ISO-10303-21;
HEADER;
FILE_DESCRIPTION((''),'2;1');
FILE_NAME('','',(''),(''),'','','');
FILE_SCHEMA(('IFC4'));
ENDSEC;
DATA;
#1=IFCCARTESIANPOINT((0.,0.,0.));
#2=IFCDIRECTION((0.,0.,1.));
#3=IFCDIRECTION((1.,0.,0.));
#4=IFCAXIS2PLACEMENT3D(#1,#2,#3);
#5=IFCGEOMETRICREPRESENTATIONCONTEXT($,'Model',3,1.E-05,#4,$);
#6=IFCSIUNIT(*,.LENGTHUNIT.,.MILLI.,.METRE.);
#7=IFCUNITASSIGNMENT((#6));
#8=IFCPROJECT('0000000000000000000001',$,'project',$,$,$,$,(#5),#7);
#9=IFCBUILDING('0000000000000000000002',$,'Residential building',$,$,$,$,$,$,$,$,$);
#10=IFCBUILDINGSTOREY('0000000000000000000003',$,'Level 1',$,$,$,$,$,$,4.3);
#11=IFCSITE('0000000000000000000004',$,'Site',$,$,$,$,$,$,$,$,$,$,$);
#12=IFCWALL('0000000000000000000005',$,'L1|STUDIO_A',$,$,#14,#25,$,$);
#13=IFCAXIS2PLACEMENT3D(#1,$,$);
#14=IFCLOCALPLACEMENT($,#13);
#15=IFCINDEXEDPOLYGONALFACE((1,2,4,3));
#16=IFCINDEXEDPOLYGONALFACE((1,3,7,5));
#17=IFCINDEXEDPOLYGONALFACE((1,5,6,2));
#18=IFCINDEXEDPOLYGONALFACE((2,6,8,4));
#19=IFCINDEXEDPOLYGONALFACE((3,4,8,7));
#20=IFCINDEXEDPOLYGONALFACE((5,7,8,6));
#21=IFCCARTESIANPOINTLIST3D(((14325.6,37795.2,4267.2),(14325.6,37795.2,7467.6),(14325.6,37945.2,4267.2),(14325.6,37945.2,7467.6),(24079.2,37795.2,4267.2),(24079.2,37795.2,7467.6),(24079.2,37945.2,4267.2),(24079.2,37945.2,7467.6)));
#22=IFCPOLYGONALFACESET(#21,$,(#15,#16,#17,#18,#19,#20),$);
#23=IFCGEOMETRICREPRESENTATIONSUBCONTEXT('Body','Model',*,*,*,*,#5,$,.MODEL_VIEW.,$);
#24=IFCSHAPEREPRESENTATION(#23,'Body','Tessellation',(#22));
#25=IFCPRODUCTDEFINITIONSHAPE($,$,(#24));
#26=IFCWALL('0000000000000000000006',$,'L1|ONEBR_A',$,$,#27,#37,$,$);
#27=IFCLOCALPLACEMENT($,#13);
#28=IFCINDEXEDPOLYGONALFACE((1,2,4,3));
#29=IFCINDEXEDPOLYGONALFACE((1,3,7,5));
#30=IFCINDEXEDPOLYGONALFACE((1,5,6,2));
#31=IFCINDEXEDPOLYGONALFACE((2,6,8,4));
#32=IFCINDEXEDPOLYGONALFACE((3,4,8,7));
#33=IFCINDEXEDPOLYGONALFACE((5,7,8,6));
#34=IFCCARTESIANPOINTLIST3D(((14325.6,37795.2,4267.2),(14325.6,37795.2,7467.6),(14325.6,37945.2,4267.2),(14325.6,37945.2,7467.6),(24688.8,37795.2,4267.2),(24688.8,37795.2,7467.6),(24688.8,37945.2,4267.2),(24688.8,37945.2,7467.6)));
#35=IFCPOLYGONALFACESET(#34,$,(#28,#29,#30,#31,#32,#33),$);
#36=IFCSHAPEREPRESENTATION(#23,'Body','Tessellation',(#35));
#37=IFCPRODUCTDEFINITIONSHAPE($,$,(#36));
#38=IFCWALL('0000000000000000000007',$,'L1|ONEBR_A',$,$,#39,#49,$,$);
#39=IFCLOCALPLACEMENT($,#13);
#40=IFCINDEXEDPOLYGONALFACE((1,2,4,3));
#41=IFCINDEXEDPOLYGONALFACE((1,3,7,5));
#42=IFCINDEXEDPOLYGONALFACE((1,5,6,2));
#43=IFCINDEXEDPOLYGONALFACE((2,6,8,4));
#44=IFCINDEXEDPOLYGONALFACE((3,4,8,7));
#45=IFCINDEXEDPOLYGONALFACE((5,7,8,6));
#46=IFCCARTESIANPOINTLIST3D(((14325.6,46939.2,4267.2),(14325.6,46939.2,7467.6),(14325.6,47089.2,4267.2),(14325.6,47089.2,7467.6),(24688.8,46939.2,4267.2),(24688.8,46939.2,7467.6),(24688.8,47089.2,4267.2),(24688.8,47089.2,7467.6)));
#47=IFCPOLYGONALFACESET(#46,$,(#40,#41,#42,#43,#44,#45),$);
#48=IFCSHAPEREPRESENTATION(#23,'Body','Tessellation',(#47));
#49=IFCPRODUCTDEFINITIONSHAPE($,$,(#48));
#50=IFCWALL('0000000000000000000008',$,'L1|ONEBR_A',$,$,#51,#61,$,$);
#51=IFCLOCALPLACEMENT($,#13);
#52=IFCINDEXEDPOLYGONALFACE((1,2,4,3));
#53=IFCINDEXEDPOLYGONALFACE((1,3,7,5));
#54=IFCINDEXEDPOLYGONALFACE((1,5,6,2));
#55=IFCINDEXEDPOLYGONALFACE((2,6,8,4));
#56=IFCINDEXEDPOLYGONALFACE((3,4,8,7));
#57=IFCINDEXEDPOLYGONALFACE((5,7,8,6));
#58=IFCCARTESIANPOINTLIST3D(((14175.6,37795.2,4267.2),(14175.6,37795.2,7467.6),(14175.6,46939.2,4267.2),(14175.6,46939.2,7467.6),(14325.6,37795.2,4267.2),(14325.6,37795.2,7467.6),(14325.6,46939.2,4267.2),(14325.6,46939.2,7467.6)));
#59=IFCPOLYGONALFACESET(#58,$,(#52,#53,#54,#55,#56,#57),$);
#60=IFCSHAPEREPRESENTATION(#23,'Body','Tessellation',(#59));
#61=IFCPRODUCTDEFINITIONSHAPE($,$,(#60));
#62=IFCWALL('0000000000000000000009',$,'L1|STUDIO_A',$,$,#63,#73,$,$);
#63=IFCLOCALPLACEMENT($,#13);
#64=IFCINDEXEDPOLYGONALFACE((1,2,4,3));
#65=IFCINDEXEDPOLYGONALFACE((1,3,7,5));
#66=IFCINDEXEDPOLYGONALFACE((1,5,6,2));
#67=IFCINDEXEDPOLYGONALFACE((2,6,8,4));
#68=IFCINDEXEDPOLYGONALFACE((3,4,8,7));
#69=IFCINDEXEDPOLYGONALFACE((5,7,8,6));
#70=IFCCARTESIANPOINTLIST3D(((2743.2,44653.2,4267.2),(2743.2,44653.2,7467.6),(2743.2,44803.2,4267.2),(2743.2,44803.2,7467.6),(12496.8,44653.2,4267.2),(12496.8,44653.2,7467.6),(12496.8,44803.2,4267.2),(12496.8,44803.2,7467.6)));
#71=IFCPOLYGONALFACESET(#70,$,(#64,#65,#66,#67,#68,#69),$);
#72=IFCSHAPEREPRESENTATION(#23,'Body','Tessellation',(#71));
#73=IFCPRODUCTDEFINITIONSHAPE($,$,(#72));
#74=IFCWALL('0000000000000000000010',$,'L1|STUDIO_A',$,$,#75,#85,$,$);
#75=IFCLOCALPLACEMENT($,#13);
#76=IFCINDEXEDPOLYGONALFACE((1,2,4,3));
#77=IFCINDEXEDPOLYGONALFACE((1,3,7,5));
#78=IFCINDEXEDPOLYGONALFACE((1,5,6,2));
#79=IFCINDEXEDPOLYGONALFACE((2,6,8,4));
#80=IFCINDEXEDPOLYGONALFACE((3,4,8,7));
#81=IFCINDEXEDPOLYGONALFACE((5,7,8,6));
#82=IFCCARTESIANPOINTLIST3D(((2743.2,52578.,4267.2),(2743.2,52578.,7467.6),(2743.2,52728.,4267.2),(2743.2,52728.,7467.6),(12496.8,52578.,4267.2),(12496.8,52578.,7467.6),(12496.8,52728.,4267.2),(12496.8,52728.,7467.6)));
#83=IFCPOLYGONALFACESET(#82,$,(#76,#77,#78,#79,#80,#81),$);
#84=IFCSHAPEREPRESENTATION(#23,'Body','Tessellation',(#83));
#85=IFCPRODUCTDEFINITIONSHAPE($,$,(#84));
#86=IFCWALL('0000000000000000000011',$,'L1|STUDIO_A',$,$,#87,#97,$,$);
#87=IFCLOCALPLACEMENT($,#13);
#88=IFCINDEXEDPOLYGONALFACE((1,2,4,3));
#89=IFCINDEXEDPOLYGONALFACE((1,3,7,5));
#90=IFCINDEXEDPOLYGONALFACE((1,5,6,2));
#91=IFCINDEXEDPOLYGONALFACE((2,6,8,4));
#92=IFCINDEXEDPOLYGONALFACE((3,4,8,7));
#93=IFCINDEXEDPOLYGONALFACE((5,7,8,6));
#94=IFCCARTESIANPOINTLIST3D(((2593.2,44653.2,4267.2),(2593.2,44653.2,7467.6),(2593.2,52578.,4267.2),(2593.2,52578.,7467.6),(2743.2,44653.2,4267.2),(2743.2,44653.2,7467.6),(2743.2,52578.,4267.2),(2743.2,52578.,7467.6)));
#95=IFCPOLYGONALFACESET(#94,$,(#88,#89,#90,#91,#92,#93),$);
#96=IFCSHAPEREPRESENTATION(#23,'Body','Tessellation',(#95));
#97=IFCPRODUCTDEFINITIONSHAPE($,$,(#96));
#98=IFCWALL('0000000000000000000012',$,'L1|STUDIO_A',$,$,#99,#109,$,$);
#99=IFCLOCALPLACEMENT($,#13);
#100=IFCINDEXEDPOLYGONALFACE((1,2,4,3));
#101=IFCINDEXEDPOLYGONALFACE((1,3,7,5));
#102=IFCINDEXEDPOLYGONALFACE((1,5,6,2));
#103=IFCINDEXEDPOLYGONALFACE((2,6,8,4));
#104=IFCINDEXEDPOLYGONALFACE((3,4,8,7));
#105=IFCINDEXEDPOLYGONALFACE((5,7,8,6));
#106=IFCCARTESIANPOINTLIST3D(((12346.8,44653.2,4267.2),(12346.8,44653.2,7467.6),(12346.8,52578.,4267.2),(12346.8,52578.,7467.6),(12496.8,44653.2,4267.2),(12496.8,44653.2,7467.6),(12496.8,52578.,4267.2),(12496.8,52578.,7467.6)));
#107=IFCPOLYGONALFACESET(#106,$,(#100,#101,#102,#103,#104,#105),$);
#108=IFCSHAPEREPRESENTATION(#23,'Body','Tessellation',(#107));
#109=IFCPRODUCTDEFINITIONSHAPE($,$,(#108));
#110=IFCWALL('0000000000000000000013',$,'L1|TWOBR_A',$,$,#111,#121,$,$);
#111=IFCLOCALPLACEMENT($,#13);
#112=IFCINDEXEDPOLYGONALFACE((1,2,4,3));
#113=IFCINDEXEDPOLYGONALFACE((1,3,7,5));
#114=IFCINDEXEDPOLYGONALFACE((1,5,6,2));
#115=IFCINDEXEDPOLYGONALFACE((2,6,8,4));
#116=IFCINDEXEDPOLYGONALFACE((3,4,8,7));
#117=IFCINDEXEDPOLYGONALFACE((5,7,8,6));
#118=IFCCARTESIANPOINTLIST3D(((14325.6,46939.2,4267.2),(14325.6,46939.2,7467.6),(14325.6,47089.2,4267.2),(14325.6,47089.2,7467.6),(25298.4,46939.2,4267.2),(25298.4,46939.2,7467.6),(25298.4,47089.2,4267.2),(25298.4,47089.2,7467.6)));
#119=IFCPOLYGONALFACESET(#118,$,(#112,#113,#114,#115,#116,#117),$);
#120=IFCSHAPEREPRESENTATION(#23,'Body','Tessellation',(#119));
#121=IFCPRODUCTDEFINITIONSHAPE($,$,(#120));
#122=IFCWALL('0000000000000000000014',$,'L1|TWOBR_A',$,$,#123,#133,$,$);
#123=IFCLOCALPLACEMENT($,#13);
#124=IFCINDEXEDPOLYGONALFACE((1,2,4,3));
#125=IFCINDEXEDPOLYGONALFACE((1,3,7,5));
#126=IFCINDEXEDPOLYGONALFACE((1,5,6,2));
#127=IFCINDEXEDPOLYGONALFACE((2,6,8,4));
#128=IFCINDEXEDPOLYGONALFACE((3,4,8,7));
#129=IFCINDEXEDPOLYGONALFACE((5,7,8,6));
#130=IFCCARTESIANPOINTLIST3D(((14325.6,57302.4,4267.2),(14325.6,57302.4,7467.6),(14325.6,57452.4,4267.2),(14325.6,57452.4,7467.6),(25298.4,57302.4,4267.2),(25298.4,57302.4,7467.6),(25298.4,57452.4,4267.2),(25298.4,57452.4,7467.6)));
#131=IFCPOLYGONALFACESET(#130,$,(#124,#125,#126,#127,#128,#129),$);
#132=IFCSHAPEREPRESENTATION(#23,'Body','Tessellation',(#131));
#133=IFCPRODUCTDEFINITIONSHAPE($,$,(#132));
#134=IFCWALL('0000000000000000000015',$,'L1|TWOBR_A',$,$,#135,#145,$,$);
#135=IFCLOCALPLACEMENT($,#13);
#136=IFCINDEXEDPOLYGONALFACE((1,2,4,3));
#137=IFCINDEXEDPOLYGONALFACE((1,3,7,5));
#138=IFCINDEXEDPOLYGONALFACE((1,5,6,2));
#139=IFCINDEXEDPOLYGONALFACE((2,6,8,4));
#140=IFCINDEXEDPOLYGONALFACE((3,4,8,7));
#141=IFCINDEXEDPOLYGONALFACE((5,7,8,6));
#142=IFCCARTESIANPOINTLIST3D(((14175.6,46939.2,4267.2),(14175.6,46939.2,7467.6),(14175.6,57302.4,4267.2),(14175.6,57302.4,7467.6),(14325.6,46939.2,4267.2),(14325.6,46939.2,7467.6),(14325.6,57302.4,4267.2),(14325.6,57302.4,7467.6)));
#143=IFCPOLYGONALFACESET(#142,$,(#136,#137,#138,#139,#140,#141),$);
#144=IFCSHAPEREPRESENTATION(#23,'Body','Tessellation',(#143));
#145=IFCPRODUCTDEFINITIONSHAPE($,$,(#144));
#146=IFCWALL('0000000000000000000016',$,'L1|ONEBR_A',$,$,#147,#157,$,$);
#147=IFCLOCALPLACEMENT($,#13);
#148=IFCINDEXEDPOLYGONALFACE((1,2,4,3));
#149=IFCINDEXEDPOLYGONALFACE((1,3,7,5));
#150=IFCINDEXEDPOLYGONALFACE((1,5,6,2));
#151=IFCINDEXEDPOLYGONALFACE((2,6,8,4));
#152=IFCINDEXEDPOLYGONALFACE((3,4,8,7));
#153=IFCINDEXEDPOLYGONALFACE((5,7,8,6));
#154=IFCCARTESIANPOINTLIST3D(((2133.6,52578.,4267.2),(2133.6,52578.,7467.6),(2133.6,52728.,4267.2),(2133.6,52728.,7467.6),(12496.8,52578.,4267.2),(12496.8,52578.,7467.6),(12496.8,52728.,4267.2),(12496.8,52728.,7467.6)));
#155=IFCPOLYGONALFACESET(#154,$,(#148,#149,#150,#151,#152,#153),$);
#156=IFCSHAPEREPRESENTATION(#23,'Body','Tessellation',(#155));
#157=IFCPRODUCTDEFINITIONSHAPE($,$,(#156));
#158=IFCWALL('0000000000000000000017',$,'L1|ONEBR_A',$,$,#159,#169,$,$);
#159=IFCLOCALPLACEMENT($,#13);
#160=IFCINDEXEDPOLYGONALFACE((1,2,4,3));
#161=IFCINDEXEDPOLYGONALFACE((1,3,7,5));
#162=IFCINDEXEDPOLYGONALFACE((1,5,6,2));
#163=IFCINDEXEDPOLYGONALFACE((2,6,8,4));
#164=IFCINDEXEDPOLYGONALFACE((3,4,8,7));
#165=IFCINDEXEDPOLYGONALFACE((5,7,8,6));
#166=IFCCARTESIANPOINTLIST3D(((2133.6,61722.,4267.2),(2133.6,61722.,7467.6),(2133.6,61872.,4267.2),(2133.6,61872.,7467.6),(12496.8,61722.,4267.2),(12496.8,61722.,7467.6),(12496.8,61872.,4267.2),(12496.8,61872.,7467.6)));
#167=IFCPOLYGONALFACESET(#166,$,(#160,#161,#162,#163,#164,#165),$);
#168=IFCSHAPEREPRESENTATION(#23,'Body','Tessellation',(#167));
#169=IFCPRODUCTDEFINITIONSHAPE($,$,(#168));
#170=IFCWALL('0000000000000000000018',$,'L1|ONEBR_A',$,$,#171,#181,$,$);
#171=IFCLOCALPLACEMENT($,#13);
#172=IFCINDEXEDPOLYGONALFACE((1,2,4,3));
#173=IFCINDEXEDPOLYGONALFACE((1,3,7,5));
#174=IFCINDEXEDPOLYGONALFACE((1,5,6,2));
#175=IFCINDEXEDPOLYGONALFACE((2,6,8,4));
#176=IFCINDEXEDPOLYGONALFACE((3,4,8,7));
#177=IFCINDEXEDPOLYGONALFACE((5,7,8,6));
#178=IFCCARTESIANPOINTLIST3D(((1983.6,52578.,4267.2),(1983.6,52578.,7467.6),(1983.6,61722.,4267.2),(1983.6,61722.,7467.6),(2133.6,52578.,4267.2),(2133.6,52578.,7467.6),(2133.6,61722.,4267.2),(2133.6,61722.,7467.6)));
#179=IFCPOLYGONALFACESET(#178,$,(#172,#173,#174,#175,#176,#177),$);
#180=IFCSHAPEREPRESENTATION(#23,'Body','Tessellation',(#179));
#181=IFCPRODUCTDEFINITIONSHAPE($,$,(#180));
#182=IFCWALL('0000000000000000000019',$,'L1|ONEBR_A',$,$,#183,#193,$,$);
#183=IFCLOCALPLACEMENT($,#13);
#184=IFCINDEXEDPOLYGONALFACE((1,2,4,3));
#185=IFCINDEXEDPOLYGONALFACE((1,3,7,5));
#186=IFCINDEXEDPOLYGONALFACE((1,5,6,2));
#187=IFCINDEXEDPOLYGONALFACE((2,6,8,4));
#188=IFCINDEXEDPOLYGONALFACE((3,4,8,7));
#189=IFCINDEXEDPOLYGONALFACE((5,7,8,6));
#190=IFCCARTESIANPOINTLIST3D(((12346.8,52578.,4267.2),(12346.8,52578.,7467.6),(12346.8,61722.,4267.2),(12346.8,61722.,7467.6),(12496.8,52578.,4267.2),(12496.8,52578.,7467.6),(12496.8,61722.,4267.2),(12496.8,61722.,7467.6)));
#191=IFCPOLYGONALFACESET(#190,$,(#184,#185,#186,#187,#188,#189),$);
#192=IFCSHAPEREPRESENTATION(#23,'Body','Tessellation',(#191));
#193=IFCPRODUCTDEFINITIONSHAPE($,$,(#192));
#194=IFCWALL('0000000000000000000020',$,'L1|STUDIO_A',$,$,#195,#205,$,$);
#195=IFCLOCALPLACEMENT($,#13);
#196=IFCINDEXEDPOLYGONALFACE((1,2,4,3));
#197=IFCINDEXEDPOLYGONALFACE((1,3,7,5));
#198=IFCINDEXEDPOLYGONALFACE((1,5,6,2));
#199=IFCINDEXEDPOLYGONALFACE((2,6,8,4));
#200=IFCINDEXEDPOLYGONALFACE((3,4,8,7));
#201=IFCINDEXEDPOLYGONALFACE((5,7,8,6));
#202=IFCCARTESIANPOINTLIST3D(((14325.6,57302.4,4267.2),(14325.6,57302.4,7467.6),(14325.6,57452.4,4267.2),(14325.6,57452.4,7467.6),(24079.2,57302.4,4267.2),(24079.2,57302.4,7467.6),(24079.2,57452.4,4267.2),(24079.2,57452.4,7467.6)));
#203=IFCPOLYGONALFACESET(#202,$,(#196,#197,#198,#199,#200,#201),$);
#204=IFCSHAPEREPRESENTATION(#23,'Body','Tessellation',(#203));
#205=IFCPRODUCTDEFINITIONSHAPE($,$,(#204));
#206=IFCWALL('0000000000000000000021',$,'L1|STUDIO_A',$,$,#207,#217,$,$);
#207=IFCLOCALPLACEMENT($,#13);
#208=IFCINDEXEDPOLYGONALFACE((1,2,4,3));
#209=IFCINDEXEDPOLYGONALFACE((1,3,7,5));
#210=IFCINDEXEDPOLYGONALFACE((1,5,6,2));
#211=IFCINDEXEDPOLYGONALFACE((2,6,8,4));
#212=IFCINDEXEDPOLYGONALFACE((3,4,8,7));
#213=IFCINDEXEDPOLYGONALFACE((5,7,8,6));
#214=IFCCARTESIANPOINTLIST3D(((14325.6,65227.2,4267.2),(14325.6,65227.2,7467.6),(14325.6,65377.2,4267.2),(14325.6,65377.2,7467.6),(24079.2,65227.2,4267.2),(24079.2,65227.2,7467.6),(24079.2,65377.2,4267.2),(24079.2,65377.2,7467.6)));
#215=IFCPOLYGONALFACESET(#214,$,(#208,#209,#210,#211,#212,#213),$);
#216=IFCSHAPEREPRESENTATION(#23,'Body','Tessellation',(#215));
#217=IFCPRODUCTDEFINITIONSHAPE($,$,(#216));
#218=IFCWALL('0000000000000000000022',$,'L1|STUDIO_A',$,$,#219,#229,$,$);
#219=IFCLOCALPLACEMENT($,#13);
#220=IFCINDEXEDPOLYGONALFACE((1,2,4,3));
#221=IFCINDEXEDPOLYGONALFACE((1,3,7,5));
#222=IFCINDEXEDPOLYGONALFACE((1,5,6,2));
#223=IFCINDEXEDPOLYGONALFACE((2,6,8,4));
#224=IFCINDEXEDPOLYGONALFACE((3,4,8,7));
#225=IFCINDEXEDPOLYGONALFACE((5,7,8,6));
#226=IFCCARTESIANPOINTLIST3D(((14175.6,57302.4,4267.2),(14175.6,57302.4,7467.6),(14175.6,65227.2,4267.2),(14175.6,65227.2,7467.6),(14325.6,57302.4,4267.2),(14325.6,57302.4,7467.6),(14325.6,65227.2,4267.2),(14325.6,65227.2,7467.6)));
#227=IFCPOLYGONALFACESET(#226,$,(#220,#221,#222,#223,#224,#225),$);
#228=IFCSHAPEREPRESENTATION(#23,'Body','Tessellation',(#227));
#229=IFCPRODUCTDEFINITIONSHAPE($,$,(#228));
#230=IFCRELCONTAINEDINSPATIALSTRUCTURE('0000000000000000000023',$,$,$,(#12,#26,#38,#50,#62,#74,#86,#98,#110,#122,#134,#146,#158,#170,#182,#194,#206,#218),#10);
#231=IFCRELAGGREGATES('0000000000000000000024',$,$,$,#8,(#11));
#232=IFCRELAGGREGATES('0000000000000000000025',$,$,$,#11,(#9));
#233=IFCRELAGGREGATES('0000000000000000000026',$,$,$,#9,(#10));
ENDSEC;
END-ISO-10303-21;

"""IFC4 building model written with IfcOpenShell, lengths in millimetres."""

from ifc_helpers import new_model, si_unit, frame, origin_with_axes, place, context, subcontext, project, spatial, indexed_curve, outline, extrude, element, save


model = new_model("IFC4")

# Units and contexts
model_context = context("Model", 3, precision=1e-05, world=origin_with_axes())
body_context = subcontext(model_context, "Body", "Model", "MODEL_VIEW")
ifc_project = project(units=[si_unit("LENGTHUNIT", "METRE", prefix="MILLI")], contexts=[model_context])

# Site, building, storey
site = spatial("IfcSite", under=ifc_project, Name="Site")
building = spatial("IfcBuilding", under=site, Name="Residential building")
storey = spatial("IfcBuildingStorey", under=building, Name="Level 1", Elevation=4.3)

# Walls
wall_1_placement = place(None, frame((14325.6, 37795.2, 4267.2), z_axis=(0.0, 0.0, 1.0), x_axis=(1.0, 0.0, 0.0)))
element("IfcWall", 1, at=wall_1_placement, inside=storey, Name="L1|STUDIO_A", context=body_context, shape_type="SweptSolid", body=[
    extrude(outline(indexed_curve([(0.0, 0.0), (0.0, 150.0), (9753.6, 150.0), (9753.6, 0.0), (0.0, 0.0)], self_intersect=False)), origin_with_axes(), (0.0, 0.0, 1.0), 3200.4),
])
for number, where, z_axis, x_axis, name in (
    (2, (14325.6, 37795.2, 4267.2), (0.0, 0.0, 1.0), (1.0, 0.0, 0.0), "L1|ONEBR_A"),
    (3, (14325.6, 46939.2, 4267.2), (0.0, 0.0, 1.0), (1.0, 0.0, 0.0), "L1|ONEBR_A"),
):
    element("IfcWall", number, at=place(None, frame(where, z_axis=z_axis, x_axis=x_axis)), inside=storey, Name=name, context=body_context, shape_type="SweptSolid", body=[
        extrude(outline(indexed_curve([(0.0, 0.0), (0.0, 150.0), (10363.2, 150.0), (10363.2, 0.0), (0.0, 0.0)], self_intersect=False)), origin_with_axes(), (0.0, 0.0, 1.0), 3200.4),
    ])
wall_2_placement = place(None, frame((14325.6, 37795.2, 4267.2), z_axis=(0.0, 0.0, 1.0), x_axis=(0.0, 1.0, 0.0)))
element("IfcWall", 4, at=wall_2_placement, inside=storey, Name="L1|ONEBR_A", context=body_context, shape_type="SweptSolid", body=[
    extrude(outline(indexed_curve([(0.0, 0.0), (0.0, 150.0), (9144.0, 150.0), (9144.0, 0.0), (0.0, 0.0)], self_intersect=False)), origin_with_axes(), (0.0, 0.0, 1.0), 3200.4),
])
for number, where, z_axis, x_axis, name in (
    (5, (2743.2, 44653.2, 4267.2), (0.0, 0.0, 1.0), (1.0, 0.0, 0.0), "L1|STUDIO_A"),
    (6, (2743.2, 52578.0, 4267.2), (0.0, 0.0, 1.0), (1.0, 0.0, 0.0), "L1|STUDIO_A"),
):
    element("IfcWall", number, at=place(None, frame(where, z_axis=z_axis, x_axis=x_axis)), inside=storey, Name=name, context=body_context, shape_type="SweptSolid", body=[
        extrude(outline(indexed_curve([(0.0, 0.0), (0.0, 150.0), (9753.6, 150.0), (9753.6, 0.0), (0.0, 0.0)], self_intersect=False)), origin_with_axes(), (0.0, 0.0, 1.0), 3200.4),
    ])
for number, where, z_axis, x_axis, name in (
    (7, (2743.2, 44653.2, 4267.2), (0.0, 0.0, 1.0), (0.0, 1.0, 0.0), "L1|STUDIO_A"),
    (8, (12496.8, 44653.2, 4267.2), (0.0, 0.0, 1.0), (0.0, 1.0, 0.0), "L1|STUDIO_A"),
):
    element("IfcWall", number, at=place(None, frame(where, z_axis=z_axis, x_axis=x_axis)), inside=storey, Name=name, context=body_context, shape_type="SweptSolid", body=[
        extrude(outline(indexed_curve([(0.0, 0.0), (0.0, 150.0), (7924.8, 150.0), (7924.8, 0.0), (0.0, 0.0)], self_intersect=False)), origin_with_axes(), (0.0, 0.0, 1.0), 3200.4),
    ])
for number, where, z_axis, x_axis, name in (
    (9, (14325.6, 46939.2, 4267.2), (0.0, 0.0, 1.0), (1.0, 0.0, 0.0), "L1|TWOBR_A"),
    (10, (14325.6, 57302.4, 4267.2), (0.0, 0.0, 1.0), (1.0, 0.0, 0.0), "L1|TWOBR_A"),
):
    element("IfcWall", number, at=place(None, frame(where, z_axis=z_axis, x_axis=x_axis)), inside=storey, Name=name, context=body_context, shape_type="SweptSolid", body=[
        extrude(outline(indexed_curve([(0.0, 0.0), (0.0, 150.0), (10972.8, 150.0), (10972.8, 0.0), (0.0, 0.0)], self_intersect=False)), origin_with_axes(), (0.0, 0.0, 1.0), 3200.4),
    ])
for number, where, z_axis, x_axis, name in (
    (11, (14325.6, 46939.2, 4267.2), (0.0, 0.0, 1.0), (0.0, 1.0, 0.0), "L1|TWOBR_A"),
    (12, (2133.6, 52578.0, 4267.2), (0.0, 0.0, 1.0), (1.0, 0.0, 0.0), "L1|ONEBR_A"),
    (13, (2133.6, 61722.0, 4267.2), (0.0, 0.0, 1.0), (1.0, 0.0, 0.0), "L1|ONEBR_A"),
):
    element("IfcWall", number, at=place(None, frame(where, z_axis=z_axis, x_axis=x_axis)), inside=storey, Name=name, context=body_context, shape_type="SweptSolid", body=[
        extrude(outline(indexed_curve([(0.0, 0.0), (0.0, 150.0), (10363.2, 150.0), (10363.2, 0.0), (0.0, 0.0)], self_intersect=False)), origin_with_axes(), (0.0, 0.0, 1.0), 3200.4),
    ])
for number, where, z_axis, x_axis, name in (
    (14, (2133.6, 52578.0, 4267.2), (0.0, 0.0, 1.0), (0.0, 1.0, 0.0), "L1|ONEBR_A"),
    (15, (12496.8, 52578.0, 4267.2), (0.0, 0.0, 1.0), (0.0, 1.0, 0.0), "L1|ONEBR_A"),
):
    element("IfcWall", number, at=place(None, frame(where, z_axis=z_axis, x_axis=x_axis)), inside=storey, Name=name, context=body_context, shape_type="SweptSolid", body=[
        extrude(outline(indexed_curve([(0.0, 0.0), (0.0, 150.0), (9144.0, 150.0), (9144.0, 0.0), (0.0, 0.0)], self_intersect=False)), origin_with_axes(), (0.0, 0.0, 1.0), 3200.4),
    ])
for number, where, z_axis, x_axis, name in (
    (16, (14325.6, 57302.4, 4267.2), (0.0, 0.0, 1.0), (1.0, 0.0, 0.0), "L1|STUDIO_A"),
    (17, (14325.6, 65227.2, 4267.2), (0.0, 0.0, 1.0), (1.0, 0.0, 0.0), "L1|STUDIO_A"),
):
    element("IfcWall", number, at=place(None, frame(where, z_axis=z_axis, x_axis=x_axis)), inside=storey, Name=name, context=body_context, shape_type="SweptSolid", body=[
        extrude(outline(indexed_curve([(0.0, 0.0), (0.0, 150.0), (9753.6, 150.0), (9753.6, 0.0), (0.0, 0.0)], self_intersect=False)), origin_with_axes(), (0.0, 0.0, 1.0), 3200.4),
    ])
wall_3_placement = place(None, frame((14325.6, 57302.4, 4267.2), z_axis=(0.0, 0.0, 1.0), x_axis=(0.0, 1.0, 0.0)))
element("IfcWall", 18, at=wall_3_placement, inside=storey, Name="L1|STUDIO_A", context=body_context, shape_type="SweptSolid", body=[
    extrude(outline(indexed_curve([(0.0, 0.0), (0.0, 150.0), (7924.8, 150.0), (7924.8, 0.0), (0.0, 0.0)], self_intersect=False)), origin_with_axes(), (0.0, 0.0, 1.0), 3200.4),
])

save(model, "model.ifc")
